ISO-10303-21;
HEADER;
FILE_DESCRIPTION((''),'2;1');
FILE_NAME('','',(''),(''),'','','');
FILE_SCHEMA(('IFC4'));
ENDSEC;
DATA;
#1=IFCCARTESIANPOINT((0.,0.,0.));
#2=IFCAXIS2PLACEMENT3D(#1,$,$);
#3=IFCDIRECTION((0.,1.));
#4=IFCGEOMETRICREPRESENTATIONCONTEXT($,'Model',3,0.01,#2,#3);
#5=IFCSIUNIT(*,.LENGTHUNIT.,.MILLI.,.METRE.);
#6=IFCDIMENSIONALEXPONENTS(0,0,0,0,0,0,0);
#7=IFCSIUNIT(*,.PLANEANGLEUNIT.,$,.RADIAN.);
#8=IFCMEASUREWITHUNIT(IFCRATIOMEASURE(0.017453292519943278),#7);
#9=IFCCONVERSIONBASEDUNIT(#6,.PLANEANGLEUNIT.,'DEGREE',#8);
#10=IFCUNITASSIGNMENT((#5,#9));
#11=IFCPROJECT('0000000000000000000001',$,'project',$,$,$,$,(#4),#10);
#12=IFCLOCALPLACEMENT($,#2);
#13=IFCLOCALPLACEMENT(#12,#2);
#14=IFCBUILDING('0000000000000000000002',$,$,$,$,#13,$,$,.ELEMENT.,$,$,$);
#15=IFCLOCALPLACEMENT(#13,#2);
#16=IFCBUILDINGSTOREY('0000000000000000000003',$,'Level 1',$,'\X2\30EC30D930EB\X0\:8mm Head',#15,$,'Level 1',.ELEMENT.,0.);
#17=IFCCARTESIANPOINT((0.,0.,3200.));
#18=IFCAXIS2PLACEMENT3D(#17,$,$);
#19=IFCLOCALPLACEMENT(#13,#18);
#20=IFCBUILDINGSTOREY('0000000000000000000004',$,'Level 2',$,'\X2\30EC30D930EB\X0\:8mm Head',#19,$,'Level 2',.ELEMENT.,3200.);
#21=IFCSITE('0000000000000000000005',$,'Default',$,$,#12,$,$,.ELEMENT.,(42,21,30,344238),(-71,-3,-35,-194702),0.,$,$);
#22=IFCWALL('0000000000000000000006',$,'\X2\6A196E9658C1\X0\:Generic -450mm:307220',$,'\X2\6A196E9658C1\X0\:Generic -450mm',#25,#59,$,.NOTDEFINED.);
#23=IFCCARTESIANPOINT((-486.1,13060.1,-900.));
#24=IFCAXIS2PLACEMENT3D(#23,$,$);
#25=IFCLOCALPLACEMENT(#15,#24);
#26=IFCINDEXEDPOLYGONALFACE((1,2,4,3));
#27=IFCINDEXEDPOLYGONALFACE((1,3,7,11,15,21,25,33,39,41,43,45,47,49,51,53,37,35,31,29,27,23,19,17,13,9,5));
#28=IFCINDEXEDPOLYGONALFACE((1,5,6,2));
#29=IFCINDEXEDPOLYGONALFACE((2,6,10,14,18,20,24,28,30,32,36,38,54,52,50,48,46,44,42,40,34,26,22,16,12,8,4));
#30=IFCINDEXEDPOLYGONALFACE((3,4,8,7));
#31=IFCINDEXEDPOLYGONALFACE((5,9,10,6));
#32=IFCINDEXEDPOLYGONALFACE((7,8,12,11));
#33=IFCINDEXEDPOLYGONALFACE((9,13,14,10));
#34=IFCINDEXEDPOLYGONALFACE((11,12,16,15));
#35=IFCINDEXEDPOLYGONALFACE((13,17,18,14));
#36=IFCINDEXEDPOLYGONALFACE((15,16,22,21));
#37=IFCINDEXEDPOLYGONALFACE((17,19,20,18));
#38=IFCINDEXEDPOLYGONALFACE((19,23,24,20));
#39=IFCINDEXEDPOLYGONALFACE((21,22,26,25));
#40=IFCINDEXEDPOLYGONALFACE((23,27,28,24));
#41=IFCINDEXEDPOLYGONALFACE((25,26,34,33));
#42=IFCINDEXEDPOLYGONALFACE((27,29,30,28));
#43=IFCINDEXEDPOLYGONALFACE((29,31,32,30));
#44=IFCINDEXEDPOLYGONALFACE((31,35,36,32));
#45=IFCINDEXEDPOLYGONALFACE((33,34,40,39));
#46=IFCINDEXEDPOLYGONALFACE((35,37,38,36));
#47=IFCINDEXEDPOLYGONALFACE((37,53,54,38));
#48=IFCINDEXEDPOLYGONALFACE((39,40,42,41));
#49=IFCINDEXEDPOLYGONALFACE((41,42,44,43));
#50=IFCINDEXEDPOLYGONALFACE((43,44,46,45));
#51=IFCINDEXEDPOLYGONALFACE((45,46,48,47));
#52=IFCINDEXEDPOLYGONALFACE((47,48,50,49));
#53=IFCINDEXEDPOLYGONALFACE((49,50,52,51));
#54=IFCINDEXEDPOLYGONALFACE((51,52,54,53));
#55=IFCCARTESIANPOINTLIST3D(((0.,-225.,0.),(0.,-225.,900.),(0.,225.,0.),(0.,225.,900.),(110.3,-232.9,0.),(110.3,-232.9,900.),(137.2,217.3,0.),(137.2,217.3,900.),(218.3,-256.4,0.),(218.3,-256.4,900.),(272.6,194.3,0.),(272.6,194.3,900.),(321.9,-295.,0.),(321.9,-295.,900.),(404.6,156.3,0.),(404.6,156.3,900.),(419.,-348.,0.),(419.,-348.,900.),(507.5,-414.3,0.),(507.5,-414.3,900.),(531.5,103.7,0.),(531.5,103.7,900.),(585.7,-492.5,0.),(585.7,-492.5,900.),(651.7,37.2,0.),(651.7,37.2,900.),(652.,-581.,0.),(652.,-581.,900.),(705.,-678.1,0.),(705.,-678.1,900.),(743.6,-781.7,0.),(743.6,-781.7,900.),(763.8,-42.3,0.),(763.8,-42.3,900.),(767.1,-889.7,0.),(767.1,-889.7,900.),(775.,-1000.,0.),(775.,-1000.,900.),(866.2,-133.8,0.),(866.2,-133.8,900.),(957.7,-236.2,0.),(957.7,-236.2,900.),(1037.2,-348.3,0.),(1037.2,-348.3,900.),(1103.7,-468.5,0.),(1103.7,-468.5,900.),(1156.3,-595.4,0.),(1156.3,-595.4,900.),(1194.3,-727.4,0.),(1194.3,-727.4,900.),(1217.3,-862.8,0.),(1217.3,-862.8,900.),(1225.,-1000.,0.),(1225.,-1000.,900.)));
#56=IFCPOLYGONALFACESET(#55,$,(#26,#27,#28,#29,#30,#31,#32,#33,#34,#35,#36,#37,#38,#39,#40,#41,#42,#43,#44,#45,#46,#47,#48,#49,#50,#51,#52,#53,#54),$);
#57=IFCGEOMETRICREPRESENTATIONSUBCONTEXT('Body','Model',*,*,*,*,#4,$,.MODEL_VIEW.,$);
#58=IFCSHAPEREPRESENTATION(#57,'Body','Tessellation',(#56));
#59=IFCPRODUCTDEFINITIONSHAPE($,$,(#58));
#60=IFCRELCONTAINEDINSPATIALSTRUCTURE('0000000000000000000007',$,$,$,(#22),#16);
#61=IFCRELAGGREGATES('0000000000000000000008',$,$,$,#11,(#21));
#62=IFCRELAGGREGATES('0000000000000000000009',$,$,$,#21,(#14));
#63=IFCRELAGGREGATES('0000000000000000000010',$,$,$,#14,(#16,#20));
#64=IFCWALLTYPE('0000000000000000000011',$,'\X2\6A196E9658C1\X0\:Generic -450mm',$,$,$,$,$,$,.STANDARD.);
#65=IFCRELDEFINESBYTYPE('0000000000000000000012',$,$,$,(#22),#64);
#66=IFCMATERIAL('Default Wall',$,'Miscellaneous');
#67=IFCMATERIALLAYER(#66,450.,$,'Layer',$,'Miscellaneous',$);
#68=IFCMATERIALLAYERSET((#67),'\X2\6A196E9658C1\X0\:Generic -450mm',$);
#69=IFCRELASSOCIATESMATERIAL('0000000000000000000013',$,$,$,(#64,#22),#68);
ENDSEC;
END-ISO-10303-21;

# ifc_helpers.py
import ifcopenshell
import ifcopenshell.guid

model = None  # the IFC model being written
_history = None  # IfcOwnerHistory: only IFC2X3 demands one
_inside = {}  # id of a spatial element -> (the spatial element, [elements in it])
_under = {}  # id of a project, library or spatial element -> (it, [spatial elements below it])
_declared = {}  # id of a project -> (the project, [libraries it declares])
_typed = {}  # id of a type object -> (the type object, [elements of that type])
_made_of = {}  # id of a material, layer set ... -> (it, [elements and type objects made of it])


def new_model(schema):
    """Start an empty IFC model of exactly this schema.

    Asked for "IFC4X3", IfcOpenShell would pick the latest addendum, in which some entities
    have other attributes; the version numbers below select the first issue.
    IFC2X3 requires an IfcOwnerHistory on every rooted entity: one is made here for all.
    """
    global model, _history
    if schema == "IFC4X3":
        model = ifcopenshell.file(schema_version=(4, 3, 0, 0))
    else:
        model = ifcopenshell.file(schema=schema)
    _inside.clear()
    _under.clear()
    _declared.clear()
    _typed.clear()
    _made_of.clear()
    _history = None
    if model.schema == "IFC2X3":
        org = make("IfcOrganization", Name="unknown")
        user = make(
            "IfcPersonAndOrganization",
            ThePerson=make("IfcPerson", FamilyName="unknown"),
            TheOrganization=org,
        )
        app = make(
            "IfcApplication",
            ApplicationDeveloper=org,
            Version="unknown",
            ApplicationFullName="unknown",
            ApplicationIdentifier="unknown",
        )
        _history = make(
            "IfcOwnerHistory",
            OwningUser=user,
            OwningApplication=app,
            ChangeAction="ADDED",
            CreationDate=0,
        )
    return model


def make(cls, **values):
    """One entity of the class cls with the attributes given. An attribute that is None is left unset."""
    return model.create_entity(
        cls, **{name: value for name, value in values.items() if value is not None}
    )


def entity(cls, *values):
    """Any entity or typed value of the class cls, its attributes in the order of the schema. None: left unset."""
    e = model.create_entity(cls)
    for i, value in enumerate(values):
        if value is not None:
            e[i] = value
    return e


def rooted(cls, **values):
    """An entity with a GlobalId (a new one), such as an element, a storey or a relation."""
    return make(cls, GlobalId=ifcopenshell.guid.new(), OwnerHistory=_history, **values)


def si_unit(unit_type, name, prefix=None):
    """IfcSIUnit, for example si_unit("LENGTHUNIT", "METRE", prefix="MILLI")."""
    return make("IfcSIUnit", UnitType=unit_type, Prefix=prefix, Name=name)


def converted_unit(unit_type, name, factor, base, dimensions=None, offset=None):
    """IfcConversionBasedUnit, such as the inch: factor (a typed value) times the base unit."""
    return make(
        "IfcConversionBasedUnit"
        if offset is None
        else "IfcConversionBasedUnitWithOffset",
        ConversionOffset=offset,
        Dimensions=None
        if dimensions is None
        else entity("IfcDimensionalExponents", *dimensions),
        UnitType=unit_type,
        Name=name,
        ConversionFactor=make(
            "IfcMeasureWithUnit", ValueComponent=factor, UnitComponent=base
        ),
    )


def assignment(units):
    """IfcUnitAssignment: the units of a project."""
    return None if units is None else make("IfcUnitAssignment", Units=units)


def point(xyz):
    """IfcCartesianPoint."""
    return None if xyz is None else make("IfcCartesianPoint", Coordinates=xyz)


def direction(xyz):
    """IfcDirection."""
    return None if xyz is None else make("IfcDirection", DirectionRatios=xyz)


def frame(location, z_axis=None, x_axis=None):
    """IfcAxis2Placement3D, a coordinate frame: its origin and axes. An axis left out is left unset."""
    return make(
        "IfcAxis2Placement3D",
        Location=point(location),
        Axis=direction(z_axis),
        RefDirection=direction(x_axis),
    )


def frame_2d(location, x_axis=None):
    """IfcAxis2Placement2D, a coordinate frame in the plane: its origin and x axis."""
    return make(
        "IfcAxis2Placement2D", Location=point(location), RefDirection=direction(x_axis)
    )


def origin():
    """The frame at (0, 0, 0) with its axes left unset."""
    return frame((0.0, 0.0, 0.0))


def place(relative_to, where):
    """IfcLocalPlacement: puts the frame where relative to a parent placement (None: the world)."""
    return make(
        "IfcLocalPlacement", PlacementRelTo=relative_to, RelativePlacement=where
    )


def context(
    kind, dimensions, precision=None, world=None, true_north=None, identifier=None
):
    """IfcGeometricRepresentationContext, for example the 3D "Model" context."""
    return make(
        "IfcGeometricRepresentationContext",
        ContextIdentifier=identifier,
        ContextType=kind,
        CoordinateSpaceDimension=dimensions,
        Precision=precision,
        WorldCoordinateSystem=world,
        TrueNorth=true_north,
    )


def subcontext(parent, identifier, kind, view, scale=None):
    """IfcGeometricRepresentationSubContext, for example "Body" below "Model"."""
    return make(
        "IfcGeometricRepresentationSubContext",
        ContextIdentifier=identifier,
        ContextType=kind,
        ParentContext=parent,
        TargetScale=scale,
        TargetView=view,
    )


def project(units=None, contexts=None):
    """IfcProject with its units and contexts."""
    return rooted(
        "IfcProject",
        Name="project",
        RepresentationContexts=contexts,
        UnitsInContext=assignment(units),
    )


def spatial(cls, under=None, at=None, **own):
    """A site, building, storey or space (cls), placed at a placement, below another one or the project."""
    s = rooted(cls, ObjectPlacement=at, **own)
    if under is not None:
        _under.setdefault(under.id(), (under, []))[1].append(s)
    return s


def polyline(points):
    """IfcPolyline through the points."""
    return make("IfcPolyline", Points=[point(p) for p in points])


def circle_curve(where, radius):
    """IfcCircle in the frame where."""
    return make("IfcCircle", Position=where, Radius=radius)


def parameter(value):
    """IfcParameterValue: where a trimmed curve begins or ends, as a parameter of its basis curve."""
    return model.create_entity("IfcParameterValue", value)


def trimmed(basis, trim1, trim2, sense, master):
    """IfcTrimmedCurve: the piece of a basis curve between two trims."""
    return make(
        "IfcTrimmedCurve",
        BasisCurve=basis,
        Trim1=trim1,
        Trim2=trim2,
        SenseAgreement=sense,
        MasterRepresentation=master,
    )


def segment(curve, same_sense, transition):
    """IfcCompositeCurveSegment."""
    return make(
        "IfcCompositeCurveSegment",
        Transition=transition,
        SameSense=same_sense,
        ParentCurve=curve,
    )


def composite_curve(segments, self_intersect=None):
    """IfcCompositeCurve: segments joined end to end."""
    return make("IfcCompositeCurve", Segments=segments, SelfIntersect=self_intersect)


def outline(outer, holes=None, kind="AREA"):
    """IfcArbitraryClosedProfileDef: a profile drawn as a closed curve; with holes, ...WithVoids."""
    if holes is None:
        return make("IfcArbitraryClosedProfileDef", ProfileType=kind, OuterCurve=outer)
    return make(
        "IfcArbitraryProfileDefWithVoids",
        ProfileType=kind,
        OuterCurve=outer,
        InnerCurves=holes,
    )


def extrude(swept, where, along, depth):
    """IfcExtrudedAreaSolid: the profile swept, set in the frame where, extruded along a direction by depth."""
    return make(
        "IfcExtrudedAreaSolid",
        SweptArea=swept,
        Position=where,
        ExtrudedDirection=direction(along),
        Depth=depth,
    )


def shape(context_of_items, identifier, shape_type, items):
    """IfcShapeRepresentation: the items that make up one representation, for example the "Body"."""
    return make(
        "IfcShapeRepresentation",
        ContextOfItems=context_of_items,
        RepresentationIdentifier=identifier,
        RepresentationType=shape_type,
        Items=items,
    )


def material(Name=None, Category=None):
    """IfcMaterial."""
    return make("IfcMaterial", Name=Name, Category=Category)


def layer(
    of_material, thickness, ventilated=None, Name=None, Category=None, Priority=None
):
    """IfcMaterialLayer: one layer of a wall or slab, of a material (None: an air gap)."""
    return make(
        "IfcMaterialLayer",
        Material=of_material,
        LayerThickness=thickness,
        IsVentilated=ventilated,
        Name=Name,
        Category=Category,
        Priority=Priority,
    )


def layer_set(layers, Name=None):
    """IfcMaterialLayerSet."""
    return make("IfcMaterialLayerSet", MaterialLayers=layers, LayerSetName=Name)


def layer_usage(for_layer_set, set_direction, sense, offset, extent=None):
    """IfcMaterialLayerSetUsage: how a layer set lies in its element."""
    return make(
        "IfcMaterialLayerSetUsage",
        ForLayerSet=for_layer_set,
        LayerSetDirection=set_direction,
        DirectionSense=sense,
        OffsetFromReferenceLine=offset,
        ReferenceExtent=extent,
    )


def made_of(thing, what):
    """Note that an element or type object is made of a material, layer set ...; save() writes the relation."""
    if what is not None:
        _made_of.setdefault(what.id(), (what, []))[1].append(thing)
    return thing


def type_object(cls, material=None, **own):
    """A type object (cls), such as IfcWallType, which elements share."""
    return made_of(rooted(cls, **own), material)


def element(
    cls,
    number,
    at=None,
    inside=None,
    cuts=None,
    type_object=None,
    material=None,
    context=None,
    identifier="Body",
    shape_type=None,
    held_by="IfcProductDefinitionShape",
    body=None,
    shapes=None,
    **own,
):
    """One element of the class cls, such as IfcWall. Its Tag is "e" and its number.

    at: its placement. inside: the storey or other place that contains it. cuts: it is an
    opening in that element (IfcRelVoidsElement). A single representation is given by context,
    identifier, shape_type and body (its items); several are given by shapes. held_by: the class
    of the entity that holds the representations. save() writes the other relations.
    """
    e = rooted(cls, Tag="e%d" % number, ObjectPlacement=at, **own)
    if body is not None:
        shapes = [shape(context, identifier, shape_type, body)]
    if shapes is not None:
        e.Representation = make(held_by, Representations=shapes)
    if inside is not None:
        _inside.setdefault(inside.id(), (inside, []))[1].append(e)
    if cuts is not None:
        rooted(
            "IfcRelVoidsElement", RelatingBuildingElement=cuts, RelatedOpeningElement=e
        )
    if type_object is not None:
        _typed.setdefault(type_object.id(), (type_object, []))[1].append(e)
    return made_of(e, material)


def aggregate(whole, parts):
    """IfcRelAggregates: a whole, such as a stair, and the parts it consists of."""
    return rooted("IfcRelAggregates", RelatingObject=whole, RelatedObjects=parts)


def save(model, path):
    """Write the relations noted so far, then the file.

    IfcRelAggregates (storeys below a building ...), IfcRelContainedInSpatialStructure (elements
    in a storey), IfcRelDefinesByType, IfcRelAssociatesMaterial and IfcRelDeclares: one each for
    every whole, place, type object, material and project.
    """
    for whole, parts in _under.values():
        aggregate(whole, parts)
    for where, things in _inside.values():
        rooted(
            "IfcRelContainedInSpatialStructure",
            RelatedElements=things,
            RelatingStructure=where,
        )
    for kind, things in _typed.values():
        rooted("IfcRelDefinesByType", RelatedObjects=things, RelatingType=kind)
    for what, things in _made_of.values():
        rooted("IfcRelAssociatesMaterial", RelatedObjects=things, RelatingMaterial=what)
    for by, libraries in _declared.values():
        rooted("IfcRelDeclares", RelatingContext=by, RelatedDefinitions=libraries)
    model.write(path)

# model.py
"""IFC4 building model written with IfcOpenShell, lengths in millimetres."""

from ifc_helpers import new_model, entity, si_unit, converted_unit, direction, frame, frame_2d, origin, place, context, subcontext, project, spatial, polyline, circle_curve, parameter, trimmed, segment, composite_curve, outline, extrude, material, layer, layer_set, layer_usage, type_object, element, save


model = new_model("IFC4")

# Units and contexts
model_context = context("Model", 3, precision=0.01, world=origin(), true_north=direction((0.0, 1.0)))
body_context = subcontext(model_context, "Body", "Model", "MODEL_VIEW")
ifc_project = project(units=[si_unit("LENGTHUNIT", "METRE", prefix="MILLI"), converted_unit("PLANEANGLEUNIT", "DEGREE", entity("IfcRatioMeasure", 0.017453292519943278), si_unit("PLANEANGLEUNIT", "RADIAN"), dimensions=[0, 0, 0, 0, 0, 0, 0])], contexts=[model_context])

# Site, building, storey
site_placement = place(None, origin())
site = spatial("IfcSite", under=ifc_project, at=site_placement, Name="Default", CompositionType="ELEMENT", RefLatitude=(42, 21, 30, 344238), RefLongitude=(-71, -3, -35, -194702), RefElevation=0.0)
building_placement = place(site_placement, origin())
building = spatial("IfcBuilding", under=site, at=building_placement, CompositionType="ELEMENT")
storey_1_placement = place(building_placement, origin())
storey_1 = spatial("IfcBuildingStorey", under=building, at=storey_1_placement, Name="Level 1", ObjectType="レベル:8mm Head", LongName="Level 1", CompositionType="ELEMENT", Elevation=0.0)

# Shared definitions
ifc_material_1 = material(Name="Default Wall", Category="Miscellaneous")
ifc_layer_1 = layer(ifc_material_1, 450.0, Name="Layer", Category="Miscellaneous")
ifc_layer_set_1 = layer_set([ifc_layer_1], Name="標準壁:Generic -450mm")
wall_type_1 = type_object("IfcWallType", Name="標準壁:Generic -450mm", PredefinedType="STANDARD", material=ifc_layer_set_1)

# Shared definitions
storey_2_placement = place(building_placement, frame((0.0, 0.0, 3200.0)))
storey_2 = spatial("IfcBuildingStorey", under=building, at=storey_2_placement, Name="Level 2", ObjectType="レベル:8mm Head", LongName="Level 2", CompositionType="ELEMENT", Elevation=3200.0)

# Wall
ifc_layer_usage_1 = layer_usage(ifc_layer_set_1, "AXIS2", "POSITIVE", -225.0)
wall_1_placement = place(storey_1_placement, frame((-486.1, 13060.1, -900.0)))
element("IfcWall", 1, at=wall_1_placement, inside=storey_1, type_object=wall_type_1, material=ifc_layer_usage_1, Name="標準壁:Generic -450mm:307220", ObjectType="標準壁:Generic -450mm", PredefinedType="NOTDEFINED", context=body_context, shape_type="SweptSolid", body=[
    extrude(outline(composite_curve([segment(trimmed(circle_curve(frame_2d((0.0, -1000.0), x_axis=(1.0, 0.0)), 1225.0), [parameter(0.0)], [parameter(90.0)], True, "PARAMETER"), True, "CONTINUOUS"), segment(polyline([(0.0, 225.0), (0.0, -225.0)]), True, "CONTINUOUS"), segment(trimmed(circle_curve(frame_2d((0.0, -1000.0), x_axis=(1.0, 0.0)), 775.0), [parameter(0.0)], [parameter(90.0)], True, "PARAMETER"), False, "CONTINUOUS"), segment(polyline([(775.0, -1000.0), (1225.0, -1000.0)]), True, "CONTINUOUS")], self_intersect=False)), origin(), (0.0, 0.0, 1.0), 900.0),
])

save(model, "model.ifc")
